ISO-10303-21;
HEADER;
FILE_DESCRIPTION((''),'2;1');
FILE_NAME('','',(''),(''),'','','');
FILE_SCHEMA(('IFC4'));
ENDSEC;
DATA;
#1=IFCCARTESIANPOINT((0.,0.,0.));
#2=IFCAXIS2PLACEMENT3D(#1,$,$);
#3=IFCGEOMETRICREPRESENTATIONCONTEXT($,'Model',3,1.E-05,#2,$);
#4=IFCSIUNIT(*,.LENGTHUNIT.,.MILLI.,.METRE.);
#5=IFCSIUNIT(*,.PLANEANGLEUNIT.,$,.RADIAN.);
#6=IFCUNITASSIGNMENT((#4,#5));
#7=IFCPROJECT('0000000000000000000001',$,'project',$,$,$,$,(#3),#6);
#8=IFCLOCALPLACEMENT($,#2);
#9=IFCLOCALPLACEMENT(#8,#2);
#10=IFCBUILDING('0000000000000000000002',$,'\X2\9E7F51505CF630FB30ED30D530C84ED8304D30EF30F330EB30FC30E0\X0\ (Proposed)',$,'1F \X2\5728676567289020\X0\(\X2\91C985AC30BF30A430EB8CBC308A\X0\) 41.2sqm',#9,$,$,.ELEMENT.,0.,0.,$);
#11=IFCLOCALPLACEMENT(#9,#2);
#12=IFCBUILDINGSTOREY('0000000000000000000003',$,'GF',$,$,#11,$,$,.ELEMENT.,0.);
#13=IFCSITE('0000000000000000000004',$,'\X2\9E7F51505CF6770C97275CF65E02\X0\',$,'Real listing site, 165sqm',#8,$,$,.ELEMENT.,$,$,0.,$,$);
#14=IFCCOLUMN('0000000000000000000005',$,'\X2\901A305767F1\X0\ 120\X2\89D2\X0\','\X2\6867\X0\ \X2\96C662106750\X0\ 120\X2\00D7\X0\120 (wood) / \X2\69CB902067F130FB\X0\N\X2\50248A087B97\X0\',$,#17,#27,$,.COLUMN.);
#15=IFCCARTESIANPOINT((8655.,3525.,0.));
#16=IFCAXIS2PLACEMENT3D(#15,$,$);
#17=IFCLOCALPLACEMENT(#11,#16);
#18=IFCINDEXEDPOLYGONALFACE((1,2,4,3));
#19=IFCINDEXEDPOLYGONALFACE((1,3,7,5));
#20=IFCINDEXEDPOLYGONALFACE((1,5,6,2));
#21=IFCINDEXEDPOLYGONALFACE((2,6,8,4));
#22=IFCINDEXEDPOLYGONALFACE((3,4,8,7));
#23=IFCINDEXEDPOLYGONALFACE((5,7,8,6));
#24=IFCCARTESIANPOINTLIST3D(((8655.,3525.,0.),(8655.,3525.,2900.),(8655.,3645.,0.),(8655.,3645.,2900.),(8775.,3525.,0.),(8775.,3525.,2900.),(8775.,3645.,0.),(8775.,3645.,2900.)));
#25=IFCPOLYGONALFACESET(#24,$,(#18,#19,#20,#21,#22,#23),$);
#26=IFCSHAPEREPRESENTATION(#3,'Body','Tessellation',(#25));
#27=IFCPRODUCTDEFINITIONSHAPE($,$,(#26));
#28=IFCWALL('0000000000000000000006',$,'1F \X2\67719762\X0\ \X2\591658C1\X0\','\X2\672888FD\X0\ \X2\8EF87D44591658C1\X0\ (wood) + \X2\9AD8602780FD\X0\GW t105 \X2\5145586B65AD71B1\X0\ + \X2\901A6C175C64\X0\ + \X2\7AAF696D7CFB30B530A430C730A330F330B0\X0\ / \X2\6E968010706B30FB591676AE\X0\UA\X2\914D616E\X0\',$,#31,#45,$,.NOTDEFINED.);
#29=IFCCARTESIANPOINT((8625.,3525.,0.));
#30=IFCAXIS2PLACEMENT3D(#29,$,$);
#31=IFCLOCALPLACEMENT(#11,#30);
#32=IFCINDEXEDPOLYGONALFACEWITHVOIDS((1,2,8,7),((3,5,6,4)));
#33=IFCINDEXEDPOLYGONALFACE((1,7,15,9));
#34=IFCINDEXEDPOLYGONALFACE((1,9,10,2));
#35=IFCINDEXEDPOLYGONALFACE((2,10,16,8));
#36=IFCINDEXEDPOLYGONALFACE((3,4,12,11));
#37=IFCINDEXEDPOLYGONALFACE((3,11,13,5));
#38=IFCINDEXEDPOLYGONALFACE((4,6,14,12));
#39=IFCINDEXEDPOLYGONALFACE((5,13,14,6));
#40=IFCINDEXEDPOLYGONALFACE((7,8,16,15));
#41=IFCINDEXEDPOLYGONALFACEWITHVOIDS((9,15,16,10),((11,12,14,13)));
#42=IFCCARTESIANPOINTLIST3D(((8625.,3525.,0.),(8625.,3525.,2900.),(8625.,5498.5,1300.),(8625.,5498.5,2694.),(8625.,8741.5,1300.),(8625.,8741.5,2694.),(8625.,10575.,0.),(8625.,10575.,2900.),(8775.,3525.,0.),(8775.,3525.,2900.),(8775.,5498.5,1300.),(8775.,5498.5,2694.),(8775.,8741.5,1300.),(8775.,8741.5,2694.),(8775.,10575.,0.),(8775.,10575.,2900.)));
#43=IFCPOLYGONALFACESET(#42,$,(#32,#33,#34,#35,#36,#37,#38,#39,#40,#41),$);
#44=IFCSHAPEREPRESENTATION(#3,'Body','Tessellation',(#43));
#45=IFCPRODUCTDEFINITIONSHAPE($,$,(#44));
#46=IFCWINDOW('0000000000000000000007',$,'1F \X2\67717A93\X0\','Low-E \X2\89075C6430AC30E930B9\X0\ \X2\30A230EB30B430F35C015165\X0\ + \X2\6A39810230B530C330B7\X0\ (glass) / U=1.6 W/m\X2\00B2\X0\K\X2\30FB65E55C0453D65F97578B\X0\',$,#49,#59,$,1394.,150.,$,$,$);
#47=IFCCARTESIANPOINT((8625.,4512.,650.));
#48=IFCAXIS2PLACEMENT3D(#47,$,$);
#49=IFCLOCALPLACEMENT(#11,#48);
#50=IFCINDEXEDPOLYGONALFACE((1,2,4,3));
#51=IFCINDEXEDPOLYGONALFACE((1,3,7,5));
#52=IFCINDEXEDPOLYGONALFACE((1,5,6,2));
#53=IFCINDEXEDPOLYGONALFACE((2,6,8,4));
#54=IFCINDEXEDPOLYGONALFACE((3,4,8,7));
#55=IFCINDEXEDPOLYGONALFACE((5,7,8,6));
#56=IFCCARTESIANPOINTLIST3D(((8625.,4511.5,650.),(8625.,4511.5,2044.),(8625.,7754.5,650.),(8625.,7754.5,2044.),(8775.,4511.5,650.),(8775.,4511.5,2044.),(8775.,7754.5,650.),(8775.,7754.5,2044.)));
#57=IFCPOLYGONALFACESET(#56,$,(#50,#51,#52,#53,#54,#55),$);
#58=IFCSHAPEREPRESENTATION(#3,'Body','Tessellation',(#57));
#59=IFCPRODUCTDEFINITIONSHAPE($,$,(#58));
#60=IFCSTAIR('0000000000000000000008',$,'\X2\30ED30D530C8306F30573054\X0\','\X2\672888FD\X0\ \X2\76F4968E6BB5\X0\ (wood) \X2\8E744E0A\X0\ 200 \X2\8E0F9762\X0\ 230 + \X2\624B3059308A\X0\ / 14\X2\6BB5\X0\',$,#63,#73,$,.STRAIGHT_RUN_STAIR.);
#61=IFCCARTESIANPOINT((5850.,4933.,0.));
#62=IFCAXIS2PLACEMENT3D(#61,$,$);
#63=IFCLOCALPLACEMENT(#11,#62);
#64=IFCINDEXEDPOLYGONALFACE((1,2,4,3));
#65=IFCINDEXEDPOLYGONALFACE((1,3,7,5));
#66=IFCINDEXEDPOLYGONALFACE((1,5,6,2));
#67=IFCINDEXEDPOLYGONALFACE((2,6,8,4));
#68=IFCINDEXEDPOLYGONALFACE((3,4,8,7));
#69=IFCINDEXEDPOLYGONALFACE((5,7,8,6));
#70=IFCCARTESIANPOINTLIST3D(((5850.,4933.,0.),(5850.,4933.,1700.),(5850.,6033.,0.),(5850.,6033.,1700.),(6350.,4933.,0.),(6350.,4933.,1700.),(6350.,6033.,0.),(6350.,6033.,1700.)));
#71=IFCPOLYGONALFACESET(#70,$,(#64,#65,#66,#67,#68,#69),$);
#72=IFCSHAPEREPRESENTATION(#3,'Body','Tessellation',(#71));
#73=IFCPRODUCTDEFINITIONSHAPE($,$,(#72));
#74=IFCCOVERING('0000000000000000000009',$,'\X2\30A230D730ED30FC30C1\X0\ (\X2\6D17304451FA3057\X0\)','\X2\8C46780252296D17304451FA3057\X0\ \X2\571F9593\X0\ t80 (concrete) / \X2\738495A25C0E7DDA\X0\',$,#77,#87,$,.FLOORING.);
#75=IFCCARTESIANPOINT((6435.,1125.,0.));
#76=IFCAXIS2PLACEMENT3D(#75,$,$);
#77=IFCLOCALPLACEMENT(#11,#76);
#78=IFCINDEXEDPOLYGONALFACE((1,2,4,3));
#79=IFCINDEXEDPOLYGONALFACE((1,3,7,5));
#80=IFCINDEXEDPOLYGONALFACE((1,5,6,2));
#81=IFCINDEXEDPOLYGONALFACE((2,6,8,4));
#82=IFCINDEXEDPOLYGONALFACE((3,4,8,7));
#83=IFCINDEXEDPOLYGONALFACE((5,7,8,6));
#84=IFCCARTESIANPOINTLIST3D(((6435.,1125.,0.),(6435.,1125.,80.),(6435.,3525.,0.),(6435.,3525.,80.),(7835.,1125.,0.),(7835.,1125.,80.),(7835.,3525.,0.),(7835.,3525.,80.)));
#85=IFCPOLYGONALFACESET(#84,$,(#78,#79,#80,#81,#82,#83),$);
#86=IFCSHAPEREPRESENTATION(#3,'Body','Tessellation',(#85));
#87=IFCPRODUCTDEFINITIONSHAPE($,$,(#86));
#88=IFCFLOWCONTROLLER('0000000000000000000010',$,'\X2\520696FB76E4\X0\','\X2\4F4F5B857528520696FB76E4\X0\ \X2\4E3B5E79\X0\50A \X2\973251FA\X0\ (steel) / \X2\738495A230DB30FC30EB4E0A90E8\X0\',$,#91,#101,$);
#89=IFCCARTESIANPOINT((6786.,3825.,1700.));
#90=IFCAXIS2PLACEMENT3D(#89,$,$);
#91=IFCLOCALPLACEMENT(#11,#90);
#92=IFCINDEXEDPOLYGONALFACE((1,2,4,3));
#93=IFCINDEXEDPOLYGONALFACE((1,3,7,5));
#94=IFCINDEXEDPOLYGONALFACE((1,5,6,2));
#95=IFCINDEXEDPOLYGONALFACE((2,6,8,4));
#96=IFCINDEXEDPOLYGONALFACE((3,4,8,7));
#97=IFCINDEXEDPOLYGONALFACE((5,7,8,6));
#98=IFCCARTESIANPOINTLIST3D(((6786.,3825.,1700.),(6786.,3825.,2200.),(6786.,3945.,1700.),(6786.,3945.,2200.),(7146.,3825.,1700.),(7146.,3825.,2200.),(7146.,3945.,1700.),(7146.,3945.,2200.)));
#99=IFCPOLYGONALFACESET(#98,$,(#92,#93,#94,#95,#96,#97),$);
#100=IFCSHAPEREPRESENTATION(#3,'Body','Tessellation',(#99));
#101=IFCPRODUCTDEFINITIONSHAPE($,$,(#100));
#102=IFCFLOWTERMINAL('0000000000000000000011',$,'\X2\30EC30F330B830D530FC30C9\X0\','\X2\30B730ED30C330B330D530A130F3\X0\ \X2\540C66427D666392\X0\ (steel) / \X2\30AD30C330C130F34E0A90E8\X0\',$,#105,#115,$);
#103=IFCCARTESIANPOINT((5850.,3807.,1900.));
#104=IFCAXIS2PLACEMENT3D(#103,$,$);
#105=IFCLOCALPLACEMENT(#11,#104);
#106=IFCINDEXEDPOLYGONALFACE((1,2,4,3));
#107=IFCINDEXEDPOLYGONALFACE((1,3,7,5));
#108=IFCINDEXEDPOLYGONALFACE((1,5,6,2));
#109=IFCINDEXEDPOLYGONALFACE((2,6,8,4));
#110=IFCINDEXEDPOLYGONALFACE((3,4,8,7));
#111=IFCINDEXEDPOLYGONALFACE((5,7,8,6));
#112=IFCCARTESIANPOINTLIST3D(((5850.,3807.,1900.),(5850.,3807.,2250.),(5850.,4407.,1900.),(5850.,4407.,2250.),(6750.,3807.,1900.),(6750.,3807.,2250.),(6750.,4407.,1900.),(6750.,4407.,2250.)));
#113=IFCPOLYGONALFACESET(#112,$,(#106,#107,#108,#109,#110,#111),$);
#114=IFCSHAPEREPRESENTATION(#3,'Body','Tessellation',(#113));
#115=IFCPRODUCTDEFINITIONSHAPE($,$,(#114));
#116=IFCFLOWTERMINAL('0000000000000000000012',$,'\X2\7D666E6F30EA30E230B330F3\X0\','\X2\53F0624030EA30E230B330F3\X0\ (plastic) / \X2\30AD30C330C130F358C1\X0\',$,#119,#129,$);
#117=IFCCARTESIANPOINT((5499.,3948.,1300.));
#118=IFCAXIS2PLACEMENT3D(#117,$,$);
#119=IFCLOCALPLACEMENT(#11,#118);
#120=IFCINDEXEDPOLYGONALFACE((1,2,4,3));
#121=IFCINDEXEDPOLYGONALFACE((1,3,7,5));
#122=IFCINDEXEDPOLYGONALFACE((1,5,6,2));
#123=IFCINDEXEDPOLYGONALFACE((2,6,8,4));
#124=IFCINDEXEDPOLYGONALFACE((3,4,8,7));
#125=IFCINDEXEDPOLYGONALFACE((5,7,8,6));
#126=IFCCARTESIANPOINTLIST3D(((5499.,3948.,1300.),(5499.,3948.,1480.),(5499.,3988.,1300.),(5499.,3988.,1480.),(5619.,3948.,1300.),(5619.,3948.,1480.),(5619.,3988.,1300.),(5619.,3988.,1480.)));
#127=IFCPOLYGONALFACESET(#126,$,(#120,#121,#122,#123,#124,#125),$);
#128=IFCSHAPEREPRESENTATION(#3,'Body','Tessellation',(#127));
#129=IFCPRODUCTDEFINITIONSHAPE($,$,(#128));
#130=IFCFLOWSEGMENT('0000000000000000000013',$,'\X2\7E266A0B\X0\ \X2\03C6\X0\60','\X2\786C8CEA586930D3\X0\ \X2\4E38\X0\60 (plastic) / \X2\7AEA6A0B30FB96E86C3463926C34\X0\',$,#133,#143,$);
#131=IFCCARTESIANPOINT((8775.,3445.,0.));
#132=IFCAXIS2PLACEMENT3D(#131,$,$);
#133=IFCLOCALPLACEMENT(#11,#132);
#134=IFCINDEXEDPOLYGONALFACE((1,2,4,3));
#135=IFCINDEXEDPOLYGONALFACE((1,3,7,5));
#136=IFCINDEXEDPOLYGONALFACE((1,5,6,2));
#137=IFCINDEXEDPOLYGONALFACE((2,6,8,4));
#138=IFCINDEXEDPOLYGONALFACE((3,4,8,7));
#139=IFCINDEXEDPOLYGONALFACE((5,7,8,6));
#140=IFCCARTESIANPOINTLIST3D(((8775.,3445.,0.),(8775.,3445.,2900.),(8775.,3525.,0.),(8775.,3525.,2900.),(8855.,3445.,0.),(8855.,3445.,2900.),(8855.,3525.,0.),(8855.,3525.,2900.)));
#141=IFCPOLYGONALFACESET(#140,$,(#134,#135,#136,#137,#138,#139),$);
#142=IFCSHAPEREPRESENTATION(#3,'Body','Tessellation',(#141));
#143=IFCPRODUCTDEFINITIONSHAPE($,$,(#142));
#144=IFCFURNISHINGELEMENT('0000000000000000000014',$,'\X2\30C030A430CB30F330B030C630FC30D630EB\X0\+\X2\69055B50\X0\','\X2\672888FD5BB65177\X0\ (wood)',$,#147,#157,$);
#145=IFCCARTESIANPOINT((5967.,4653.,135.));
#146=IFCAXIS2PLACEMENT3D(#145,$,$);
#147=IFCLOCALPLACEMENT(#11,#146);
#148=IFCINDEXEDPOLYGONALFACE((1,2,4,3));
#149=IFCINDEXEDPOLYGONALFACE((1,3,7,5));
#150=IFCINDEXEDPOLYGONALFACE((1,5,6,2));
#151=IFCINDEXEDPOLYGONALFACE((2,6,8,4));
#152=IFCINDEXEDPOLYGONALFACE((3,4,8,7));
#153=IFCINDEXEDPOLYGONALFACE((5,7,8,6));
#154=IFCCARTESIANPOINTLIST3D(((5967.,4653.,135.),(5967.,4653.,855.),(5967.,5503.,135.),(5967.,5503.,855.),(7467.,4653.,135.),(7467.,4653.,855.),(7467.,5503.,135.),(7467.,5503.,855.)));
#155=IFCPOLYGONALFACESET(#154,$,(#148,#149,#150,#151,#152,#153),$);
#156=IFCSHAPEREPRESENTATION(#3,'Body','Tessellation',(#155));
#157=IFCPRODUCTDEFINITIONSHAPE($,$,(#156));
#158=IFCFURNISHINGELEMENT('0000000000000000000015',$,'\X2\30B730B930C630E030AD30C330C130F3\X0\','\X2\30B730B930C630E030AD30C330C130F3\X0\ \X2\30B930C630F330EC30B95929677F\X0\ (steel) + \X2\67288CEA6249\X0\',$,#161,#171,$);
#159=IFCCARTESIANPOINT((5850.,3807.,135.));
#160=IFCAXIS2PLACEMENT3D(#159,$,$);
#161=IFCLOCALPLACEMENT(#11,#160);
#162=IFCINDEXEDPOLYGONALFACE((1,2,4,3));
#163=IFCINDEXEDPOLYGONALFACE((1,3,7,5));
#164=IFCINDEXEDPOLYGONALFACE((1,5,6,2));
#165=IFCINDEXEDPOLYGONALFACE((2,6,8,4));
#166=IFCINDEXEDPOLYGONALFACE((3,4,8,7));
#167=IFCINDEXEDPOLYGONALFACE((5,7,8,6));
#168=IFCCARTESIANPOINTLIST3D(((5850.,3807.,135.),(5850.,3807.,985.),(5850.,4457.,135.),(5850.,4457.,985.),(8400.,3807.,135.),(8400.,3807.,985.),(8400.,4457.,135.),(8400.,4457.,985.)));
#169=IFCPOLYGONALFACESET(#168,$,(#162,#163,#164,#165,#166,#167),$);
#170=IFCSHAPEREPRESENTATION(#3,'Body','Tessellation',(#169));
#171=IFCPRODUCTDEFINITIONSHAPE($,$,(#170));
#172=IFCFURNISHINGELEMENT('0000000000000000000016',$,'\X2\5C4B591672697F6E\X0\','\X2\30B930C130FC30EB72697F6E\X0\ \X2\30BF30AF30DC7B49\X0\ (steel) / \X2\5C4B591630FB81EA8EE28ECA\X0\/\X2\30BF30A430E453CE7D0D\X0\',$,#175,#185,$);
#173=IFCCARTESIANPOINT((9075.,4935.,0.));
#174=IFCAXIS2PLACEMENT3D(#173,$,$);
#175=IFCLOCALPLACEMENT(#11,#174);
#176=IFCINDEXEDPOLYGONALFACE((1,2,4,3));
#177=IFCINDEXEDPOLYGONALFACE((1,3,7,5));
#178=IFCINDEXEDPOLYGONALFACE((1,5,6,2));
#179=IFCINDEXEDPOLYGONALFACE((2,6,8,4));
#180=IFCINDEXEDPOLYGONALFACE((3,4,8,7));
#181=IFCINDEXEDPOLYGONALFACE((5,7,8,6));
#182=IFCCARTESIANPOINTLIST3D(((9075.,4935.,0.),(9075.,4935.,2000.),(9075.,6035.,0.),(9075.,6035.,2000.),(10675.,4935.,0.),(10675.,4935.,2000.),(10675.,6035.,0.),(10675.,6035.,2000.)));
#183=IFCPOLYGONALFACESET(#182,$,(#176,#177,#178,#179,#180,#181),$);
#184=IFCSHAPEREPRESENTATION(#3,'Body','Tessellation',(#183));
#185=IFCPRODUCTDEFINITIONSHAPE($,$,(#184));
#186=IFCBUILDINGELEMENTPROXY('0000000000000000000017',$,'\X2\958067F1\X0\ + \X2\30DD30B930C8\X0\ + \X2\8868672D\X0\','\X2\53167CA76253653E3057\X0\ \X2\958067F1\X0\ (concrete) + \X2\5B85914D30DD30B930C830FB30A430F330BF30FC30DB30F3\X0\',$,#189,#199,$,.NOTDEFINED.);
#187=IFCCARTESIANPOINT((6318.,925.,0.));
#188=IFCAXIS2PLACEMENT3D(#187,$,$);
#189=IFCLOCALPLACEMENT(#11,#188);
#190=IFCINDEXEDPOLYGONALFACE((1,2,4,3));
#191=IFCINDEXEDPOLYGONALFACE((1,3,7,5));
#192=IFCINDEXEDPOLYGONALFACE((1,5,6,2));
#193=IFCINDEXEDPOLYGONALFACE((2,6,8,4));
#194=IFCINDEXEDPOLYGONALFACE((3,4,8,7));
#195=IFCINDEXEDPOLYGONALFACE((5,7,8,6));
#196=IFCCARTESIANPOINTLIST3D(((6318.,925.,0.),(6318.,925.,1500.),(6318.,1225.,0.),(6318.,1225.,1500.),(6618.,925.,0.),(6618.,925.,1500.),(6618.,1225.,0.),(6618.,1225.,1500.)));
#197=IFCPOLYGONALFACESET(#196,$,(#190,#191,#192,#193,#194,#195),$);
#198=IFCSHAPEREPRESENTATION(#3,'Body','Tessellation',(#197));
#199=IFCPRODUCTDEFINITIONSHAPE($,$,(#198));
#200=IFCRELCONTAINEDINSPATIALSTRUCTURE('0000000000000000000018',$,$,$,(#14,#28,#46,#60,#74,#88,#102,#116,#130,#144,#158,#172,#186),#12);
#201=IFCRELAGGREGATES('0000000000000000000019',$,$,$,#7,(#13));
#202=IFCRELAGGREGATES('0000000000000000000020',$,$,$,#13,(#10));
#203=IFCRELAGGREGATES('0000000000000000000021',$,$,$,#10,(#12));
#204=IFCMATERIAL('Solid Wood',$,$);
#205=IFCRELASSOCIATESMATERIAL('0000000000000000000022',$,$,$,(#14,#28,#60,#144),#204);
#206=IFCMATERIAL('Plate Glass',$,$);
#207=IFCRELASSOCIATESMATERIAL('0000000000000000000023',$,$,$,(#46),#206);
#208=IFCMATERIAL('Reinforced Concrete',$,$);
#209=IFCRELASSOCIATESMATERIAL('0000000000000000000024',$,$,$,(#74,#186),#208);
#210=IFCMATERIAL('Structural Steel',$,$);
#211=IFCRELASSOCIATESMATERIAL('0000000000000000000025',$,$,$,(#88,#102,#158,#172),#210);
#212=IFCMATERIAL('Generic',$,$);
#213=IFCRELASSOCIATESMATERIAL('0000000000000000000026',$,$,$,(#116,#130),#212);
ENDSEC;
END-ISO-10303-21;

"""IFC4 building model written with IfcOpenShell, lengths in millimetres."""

from ifc_helpers import new_model, si_unit, frame, frame_2d, origin, place, context, project, spatial, rectangle, extrude, material, element, fill, save


model = new_model("IFC4")

# Units and contexts
model_context = context("Model", 3, precision=1e-05, world=origin())
ifc_project = project(units=[si_unit("LENGTHUNIT", "METRE", prefix="MILLI"), si_unit("PLANEANGLEUNIT", "RADIAN")], contexts=[model_context])

# Site, building, storey
site_placement = place(None, origin())
site = spatial("IfcSite", under=ifc_project, at=site_placement, Name="鹿児島県霧島市", ObjectType="Real listing site, 165sqm", CompositionType="ELEMENT", RefElevation=0.0)
building_placement = place(site_placement, origin())
building = spatial("IfcBuilding", under=site, at=building_placement, Name="鹿児島・ロフト付きワンルーム (Proposed)", ObjectType="1F 在来木造(釉薬タイル貼り) 41.2sqm", CompositionType="ELEMENT", ElevationOfRefHeight=0.0, ElevationOfTerrain=0.0)
storey_placement = place(building_placement, origin())
storey = spatial("IfcBuildingStorey", under=building, at=storey_placement, Name="GF", CompositionType="ELEMENT", Elevation=0.0)

# Column
ifc_material_1 = material(Name="Solid Wood")
column_1_placement = place(storey_placement, frame((8655.0, 3525.0, 0.0)))
element("IfcColumn", 1, at=column_1_placement, inside=storey, material=ifc_material_1, Name="通し柱 120角", Description="桧 集成材 120×120 (wood) / 構造柱・N値計算", PredefinedType="COLUMN", context=model_context, shape_type="SweptSolid", body=[
    extrude(rectangle(XDim=120.0, YDim=120.0, at=frame_2d((60.0, 60.0))), frame((8655.0, 3525.0, 0.0)), (0.0, 0.0, 1.0), 2900.0),
])

# Wall, opening, window
wall_1_placement = place(storey_placement, frame((8625.0, 3525.0, 0.0)))
wall_1 = element("IfcWall", 2, at=wall_1_placement, inside=storey, material=ifc_material_1, Name="1F 東面 外壁", Description="木製 軸組外壁 (wood) + 高性能GW t105 充填断熱 + 通気層 + 窯業系サイディング / 準耐火・外皮UA配慮", PredefinedType="NOTDEFINED", context=model_context, shape_type="SweptSolid", body=[
    extrude(rectangle(XDim=150.0, YDim=7050.0, at=frame_2d((75.0, 3525.0))), frame((8625.0, 3525.0, 0.0)), (0.0, 0.0, 1.0), 2900.0),
])
opening_placement = place(storey_placement, frame((8625.0, 4512.0, 650.0)))
opening = element("IfcOpeningElement", 3, at=opening_placement, cuts=wall_1, PredefinedType="NOTDEFINED", context=model_context, shape_type="SweptSolid", body=[
    extrude(rectangle(XDim=150.0, YDim=3243.0, at=frame_2d((75.0, 1621.0))), frame((8625.0, 4512.0, 650.0)), (0.0, 0.0, 1.0), 1394.0),
])
ifc_material_2 = material(Name="Plate Glass")
window_placement = place(storey_placement, frame((8625.0, 4512.0, 650.0)))
window = element("IfcWindow", 4, at=window_placement, inside=storey, material=ifc_material_2, Name="1F 東窓", Description="Low-E 複層ガラス アルゴン封入 + 樹脂サッシ (glass) / U=1.6 W/m²K・日射取得型", OverallHeight=1394.0, OverallWidth=150.0, context=model_context, shape_type="SweptSolid", body=[
    extrude(rectangle(XDim=150.0, YDim=3243.0, at=frame_2d((75.0, 1621.0))), frame((8625.0, 4512.0, 650.0)), (0.0, 0.0, 1.0), 1394.0),
])
fill(opening, window)

# Stair
stair_placement = place(storey_placement, frame((5850.0, 4933.0, 0.0)))
element("IfcStair", 5, at=stair_placement, inside=storey, material=ifc_material_1, Name="ロフトはしご", Description="木製 直階段 (wood) 蹴上 200 踏面 230 + 手すり / 14段", PredefinedType="STRAIGHT_RUN_STAIR", context=model_context, shape_type="SweptSolid", body=[
    extrude(rectangle(XDim=500.0, YDim=1100.0, at=frame_2d((250.0, 550.0))), frame((5850.0, 4933.0, 0.0)), (0.0, 0.0, 1.0), 1700.0),
])

# Covering
ifc_material_3 = material(Name="Reinforced Concrete")
covering_placement = place(storey_placement, frame((6435.0, 1125.0, 0.0)))
element("IfcCovering", 6, at=covering_placement, inside=storey, material=ifc_material_3, Name="アプローチ (洗い出し)", Description="豆砂利洗い出し 土間 t80 (concrete) / 玄関導線", PredefinedType="FLOORING", context=model_context, shape_type="SweptSolid", body=[
    extrude(rectangle(XDim=1400.0, YDim=2400.0, at=frame_2d((700.0, 1200.0))), frame((6435.0, 1125.0, 0.0)), (0.0, 0.0, 1.0), 80.0),
])

# Flow controller
ifc_material_4 = material(Name="Structural Steel")
flow_controller_placement = place(storey_placement, frame((6786.0, 3825.0, 1700.0)))
element("IfcFlowController", 7, at=flow_controller_placement, inside=storey, material=ifc_material_4, Name="分電盤", Description="住宅用分電盤 主幹50A 露出 (steel) / 玄関ホール上部", context=model_context, shape_type="SweptSolid", body=[
    extrude(rectangle(XDim=360.0, YDim=120.0, at=frame_2d((180.0, 60.0))), frame((6786.0, 3825.0, 1700.0)), (0.0, 0.0, 1.0), 500.0),
])

# Flow terminals
flow_terminal_1_placement = place(storey_placement, frame((5850.0, 3807.0, 1900.0)))
element("IfcFlowTerminal", 8, at=flow_terminal_1_placement, inside=storey, material=ifc_material_4, Name="レンジフード", Description="シロッコファン 同時給排 (steel) / キッチン上部", context=model_context, shape_type="SweptSolid", body=[
    extrude(rectangle(XDim=900.0, YDim=600.0, at=frame_2d((450.0, 300.0))), frame((5850.0, 3807.0, 1900.0)), (0.0, 0.0, 1.0), 350.0),
])
ifc_material_5 = material(Name="Generic")
flow_terminal_2_placement = place(storey_placement, frame((5499.0, 3948.0, 1300.0)))
element("IfcFlowTerminal", 9, at=flow_terminal_2_placement, inside=storey, material=ifc_material_5, Name="給湯リモコン", Description="台所リモコン (plastic) / キッチン壁", context=model_context, shape_type="SweptSolid", body=[
    extrude(rectangle(XDim=120.0, YDim=40.0, at=frame_2d((60.0, 20.0))), frame((5499.0, 3948.0, 1300.0)), (0.0, 0.0, 1.0), 180.0),
])

# Flow segment
flow_segment_placement = place(storey_placement, frame((8775.0, 3445.0, 0.0)))
element("IfcFlowSegment", 10, at=flow_segment_placement, inside=storey, material=ifc_material_5, Name="縦樋 φ60", Description="硬質塩ビ 丸60 (plastic) / 竪樋・雨水排水", context=model_context, shape_type="SweptSolid", body=[
    extrude(rectangle(XDim=80.0, YDim=80.0, at=frame_2d((40.0, 40.0))), frame((8775.0, 3445.0, 0.0)), (0.0, 0.0, 1.0), 2900.0),
])

# Furnishing elements
furnishing_1_placement = place(storey_placement, frame((5967.0, 4653.0, 135.0)))
element("IfcFurnishingElement", 11, at=furnishing_1_placement, inside=storey, material=ifc_material_1, Name="ダイニングテーブル+椅子", Description="木製家具 (wood)", context=model_context, shape_type="SweptSolid", body=[
    extrude(rectangle(XDim=1500.0, YDim=850.0, at=frame_2d((750.0, 425.0))), frame((5967.0, 4653.0, 135.0)), (0.0, 0.0, 1.0), 720.0),
])
furnishing_2_placement = place(storey_placement, frame((5850.0, 3807.0, 135.0)))
element("IfcFurnishingElement", 12, at=furnishing_2_placement, inside=storey, material=ifc_material_4, Name="システムキッチン", Description="システムキッチン ステンレス天板 (steel) + 木質扉", context=model_context, shape_type="SweptSolid", body=[
    extrude(rectangle(XDim=2550.0, YDim=650.0, at=frame_2d((1275.0, 325.0))), frame((5850.0, 3807.0, 135.0)), (0.0, 0.0, 1.0), 850.0),
])
furnishing_3_placement = place(storey_placement, frame((9075.0, 4935.0, 0.0)))
element("IfcFurnishingElement", 13, at=furnishing_3_placement, inside=storey, material=ifc_material_4, Name="屋外物置", Description="スチール物置 タクボ等 (steel) / 屋外・自転車/タイヤ収納", context=model_context, shape_type="SweptSolid", body=[
    extrude(rectangle(XDim=1600.0, YDim=1100.0, at=frame_2d((800.0, 550.0))), frame((9075.0, 4935.0, 0.0)), (0.0, 0.0, 1.0), 2000.0),
])

# Building element proxy
proxy_placement = place(storey_placement, frame((6318.0, 925.0, 0.0)))
element("IfcBuildingElementProxy", 14, at=proxy_placement, inside=storey, material=ifc_material_3, Name="門柱 + ポスト + 表札", Description="化粧打放し 門柱 (concrete) + 宅配ポスト・インターホン", PredefinedType="NOTDEFINED", context=model_context, shape_type="SweptSolid", body=[
    extrude(rectangle(XDim=300.0, YDim=300.0, at=frame_2d((150.0, 150.0))), frame((6318.0, 925.0, 0.0)), (0.0, 0.0, 1.0), 1500.0),
])

save(model, "model.ifc")
